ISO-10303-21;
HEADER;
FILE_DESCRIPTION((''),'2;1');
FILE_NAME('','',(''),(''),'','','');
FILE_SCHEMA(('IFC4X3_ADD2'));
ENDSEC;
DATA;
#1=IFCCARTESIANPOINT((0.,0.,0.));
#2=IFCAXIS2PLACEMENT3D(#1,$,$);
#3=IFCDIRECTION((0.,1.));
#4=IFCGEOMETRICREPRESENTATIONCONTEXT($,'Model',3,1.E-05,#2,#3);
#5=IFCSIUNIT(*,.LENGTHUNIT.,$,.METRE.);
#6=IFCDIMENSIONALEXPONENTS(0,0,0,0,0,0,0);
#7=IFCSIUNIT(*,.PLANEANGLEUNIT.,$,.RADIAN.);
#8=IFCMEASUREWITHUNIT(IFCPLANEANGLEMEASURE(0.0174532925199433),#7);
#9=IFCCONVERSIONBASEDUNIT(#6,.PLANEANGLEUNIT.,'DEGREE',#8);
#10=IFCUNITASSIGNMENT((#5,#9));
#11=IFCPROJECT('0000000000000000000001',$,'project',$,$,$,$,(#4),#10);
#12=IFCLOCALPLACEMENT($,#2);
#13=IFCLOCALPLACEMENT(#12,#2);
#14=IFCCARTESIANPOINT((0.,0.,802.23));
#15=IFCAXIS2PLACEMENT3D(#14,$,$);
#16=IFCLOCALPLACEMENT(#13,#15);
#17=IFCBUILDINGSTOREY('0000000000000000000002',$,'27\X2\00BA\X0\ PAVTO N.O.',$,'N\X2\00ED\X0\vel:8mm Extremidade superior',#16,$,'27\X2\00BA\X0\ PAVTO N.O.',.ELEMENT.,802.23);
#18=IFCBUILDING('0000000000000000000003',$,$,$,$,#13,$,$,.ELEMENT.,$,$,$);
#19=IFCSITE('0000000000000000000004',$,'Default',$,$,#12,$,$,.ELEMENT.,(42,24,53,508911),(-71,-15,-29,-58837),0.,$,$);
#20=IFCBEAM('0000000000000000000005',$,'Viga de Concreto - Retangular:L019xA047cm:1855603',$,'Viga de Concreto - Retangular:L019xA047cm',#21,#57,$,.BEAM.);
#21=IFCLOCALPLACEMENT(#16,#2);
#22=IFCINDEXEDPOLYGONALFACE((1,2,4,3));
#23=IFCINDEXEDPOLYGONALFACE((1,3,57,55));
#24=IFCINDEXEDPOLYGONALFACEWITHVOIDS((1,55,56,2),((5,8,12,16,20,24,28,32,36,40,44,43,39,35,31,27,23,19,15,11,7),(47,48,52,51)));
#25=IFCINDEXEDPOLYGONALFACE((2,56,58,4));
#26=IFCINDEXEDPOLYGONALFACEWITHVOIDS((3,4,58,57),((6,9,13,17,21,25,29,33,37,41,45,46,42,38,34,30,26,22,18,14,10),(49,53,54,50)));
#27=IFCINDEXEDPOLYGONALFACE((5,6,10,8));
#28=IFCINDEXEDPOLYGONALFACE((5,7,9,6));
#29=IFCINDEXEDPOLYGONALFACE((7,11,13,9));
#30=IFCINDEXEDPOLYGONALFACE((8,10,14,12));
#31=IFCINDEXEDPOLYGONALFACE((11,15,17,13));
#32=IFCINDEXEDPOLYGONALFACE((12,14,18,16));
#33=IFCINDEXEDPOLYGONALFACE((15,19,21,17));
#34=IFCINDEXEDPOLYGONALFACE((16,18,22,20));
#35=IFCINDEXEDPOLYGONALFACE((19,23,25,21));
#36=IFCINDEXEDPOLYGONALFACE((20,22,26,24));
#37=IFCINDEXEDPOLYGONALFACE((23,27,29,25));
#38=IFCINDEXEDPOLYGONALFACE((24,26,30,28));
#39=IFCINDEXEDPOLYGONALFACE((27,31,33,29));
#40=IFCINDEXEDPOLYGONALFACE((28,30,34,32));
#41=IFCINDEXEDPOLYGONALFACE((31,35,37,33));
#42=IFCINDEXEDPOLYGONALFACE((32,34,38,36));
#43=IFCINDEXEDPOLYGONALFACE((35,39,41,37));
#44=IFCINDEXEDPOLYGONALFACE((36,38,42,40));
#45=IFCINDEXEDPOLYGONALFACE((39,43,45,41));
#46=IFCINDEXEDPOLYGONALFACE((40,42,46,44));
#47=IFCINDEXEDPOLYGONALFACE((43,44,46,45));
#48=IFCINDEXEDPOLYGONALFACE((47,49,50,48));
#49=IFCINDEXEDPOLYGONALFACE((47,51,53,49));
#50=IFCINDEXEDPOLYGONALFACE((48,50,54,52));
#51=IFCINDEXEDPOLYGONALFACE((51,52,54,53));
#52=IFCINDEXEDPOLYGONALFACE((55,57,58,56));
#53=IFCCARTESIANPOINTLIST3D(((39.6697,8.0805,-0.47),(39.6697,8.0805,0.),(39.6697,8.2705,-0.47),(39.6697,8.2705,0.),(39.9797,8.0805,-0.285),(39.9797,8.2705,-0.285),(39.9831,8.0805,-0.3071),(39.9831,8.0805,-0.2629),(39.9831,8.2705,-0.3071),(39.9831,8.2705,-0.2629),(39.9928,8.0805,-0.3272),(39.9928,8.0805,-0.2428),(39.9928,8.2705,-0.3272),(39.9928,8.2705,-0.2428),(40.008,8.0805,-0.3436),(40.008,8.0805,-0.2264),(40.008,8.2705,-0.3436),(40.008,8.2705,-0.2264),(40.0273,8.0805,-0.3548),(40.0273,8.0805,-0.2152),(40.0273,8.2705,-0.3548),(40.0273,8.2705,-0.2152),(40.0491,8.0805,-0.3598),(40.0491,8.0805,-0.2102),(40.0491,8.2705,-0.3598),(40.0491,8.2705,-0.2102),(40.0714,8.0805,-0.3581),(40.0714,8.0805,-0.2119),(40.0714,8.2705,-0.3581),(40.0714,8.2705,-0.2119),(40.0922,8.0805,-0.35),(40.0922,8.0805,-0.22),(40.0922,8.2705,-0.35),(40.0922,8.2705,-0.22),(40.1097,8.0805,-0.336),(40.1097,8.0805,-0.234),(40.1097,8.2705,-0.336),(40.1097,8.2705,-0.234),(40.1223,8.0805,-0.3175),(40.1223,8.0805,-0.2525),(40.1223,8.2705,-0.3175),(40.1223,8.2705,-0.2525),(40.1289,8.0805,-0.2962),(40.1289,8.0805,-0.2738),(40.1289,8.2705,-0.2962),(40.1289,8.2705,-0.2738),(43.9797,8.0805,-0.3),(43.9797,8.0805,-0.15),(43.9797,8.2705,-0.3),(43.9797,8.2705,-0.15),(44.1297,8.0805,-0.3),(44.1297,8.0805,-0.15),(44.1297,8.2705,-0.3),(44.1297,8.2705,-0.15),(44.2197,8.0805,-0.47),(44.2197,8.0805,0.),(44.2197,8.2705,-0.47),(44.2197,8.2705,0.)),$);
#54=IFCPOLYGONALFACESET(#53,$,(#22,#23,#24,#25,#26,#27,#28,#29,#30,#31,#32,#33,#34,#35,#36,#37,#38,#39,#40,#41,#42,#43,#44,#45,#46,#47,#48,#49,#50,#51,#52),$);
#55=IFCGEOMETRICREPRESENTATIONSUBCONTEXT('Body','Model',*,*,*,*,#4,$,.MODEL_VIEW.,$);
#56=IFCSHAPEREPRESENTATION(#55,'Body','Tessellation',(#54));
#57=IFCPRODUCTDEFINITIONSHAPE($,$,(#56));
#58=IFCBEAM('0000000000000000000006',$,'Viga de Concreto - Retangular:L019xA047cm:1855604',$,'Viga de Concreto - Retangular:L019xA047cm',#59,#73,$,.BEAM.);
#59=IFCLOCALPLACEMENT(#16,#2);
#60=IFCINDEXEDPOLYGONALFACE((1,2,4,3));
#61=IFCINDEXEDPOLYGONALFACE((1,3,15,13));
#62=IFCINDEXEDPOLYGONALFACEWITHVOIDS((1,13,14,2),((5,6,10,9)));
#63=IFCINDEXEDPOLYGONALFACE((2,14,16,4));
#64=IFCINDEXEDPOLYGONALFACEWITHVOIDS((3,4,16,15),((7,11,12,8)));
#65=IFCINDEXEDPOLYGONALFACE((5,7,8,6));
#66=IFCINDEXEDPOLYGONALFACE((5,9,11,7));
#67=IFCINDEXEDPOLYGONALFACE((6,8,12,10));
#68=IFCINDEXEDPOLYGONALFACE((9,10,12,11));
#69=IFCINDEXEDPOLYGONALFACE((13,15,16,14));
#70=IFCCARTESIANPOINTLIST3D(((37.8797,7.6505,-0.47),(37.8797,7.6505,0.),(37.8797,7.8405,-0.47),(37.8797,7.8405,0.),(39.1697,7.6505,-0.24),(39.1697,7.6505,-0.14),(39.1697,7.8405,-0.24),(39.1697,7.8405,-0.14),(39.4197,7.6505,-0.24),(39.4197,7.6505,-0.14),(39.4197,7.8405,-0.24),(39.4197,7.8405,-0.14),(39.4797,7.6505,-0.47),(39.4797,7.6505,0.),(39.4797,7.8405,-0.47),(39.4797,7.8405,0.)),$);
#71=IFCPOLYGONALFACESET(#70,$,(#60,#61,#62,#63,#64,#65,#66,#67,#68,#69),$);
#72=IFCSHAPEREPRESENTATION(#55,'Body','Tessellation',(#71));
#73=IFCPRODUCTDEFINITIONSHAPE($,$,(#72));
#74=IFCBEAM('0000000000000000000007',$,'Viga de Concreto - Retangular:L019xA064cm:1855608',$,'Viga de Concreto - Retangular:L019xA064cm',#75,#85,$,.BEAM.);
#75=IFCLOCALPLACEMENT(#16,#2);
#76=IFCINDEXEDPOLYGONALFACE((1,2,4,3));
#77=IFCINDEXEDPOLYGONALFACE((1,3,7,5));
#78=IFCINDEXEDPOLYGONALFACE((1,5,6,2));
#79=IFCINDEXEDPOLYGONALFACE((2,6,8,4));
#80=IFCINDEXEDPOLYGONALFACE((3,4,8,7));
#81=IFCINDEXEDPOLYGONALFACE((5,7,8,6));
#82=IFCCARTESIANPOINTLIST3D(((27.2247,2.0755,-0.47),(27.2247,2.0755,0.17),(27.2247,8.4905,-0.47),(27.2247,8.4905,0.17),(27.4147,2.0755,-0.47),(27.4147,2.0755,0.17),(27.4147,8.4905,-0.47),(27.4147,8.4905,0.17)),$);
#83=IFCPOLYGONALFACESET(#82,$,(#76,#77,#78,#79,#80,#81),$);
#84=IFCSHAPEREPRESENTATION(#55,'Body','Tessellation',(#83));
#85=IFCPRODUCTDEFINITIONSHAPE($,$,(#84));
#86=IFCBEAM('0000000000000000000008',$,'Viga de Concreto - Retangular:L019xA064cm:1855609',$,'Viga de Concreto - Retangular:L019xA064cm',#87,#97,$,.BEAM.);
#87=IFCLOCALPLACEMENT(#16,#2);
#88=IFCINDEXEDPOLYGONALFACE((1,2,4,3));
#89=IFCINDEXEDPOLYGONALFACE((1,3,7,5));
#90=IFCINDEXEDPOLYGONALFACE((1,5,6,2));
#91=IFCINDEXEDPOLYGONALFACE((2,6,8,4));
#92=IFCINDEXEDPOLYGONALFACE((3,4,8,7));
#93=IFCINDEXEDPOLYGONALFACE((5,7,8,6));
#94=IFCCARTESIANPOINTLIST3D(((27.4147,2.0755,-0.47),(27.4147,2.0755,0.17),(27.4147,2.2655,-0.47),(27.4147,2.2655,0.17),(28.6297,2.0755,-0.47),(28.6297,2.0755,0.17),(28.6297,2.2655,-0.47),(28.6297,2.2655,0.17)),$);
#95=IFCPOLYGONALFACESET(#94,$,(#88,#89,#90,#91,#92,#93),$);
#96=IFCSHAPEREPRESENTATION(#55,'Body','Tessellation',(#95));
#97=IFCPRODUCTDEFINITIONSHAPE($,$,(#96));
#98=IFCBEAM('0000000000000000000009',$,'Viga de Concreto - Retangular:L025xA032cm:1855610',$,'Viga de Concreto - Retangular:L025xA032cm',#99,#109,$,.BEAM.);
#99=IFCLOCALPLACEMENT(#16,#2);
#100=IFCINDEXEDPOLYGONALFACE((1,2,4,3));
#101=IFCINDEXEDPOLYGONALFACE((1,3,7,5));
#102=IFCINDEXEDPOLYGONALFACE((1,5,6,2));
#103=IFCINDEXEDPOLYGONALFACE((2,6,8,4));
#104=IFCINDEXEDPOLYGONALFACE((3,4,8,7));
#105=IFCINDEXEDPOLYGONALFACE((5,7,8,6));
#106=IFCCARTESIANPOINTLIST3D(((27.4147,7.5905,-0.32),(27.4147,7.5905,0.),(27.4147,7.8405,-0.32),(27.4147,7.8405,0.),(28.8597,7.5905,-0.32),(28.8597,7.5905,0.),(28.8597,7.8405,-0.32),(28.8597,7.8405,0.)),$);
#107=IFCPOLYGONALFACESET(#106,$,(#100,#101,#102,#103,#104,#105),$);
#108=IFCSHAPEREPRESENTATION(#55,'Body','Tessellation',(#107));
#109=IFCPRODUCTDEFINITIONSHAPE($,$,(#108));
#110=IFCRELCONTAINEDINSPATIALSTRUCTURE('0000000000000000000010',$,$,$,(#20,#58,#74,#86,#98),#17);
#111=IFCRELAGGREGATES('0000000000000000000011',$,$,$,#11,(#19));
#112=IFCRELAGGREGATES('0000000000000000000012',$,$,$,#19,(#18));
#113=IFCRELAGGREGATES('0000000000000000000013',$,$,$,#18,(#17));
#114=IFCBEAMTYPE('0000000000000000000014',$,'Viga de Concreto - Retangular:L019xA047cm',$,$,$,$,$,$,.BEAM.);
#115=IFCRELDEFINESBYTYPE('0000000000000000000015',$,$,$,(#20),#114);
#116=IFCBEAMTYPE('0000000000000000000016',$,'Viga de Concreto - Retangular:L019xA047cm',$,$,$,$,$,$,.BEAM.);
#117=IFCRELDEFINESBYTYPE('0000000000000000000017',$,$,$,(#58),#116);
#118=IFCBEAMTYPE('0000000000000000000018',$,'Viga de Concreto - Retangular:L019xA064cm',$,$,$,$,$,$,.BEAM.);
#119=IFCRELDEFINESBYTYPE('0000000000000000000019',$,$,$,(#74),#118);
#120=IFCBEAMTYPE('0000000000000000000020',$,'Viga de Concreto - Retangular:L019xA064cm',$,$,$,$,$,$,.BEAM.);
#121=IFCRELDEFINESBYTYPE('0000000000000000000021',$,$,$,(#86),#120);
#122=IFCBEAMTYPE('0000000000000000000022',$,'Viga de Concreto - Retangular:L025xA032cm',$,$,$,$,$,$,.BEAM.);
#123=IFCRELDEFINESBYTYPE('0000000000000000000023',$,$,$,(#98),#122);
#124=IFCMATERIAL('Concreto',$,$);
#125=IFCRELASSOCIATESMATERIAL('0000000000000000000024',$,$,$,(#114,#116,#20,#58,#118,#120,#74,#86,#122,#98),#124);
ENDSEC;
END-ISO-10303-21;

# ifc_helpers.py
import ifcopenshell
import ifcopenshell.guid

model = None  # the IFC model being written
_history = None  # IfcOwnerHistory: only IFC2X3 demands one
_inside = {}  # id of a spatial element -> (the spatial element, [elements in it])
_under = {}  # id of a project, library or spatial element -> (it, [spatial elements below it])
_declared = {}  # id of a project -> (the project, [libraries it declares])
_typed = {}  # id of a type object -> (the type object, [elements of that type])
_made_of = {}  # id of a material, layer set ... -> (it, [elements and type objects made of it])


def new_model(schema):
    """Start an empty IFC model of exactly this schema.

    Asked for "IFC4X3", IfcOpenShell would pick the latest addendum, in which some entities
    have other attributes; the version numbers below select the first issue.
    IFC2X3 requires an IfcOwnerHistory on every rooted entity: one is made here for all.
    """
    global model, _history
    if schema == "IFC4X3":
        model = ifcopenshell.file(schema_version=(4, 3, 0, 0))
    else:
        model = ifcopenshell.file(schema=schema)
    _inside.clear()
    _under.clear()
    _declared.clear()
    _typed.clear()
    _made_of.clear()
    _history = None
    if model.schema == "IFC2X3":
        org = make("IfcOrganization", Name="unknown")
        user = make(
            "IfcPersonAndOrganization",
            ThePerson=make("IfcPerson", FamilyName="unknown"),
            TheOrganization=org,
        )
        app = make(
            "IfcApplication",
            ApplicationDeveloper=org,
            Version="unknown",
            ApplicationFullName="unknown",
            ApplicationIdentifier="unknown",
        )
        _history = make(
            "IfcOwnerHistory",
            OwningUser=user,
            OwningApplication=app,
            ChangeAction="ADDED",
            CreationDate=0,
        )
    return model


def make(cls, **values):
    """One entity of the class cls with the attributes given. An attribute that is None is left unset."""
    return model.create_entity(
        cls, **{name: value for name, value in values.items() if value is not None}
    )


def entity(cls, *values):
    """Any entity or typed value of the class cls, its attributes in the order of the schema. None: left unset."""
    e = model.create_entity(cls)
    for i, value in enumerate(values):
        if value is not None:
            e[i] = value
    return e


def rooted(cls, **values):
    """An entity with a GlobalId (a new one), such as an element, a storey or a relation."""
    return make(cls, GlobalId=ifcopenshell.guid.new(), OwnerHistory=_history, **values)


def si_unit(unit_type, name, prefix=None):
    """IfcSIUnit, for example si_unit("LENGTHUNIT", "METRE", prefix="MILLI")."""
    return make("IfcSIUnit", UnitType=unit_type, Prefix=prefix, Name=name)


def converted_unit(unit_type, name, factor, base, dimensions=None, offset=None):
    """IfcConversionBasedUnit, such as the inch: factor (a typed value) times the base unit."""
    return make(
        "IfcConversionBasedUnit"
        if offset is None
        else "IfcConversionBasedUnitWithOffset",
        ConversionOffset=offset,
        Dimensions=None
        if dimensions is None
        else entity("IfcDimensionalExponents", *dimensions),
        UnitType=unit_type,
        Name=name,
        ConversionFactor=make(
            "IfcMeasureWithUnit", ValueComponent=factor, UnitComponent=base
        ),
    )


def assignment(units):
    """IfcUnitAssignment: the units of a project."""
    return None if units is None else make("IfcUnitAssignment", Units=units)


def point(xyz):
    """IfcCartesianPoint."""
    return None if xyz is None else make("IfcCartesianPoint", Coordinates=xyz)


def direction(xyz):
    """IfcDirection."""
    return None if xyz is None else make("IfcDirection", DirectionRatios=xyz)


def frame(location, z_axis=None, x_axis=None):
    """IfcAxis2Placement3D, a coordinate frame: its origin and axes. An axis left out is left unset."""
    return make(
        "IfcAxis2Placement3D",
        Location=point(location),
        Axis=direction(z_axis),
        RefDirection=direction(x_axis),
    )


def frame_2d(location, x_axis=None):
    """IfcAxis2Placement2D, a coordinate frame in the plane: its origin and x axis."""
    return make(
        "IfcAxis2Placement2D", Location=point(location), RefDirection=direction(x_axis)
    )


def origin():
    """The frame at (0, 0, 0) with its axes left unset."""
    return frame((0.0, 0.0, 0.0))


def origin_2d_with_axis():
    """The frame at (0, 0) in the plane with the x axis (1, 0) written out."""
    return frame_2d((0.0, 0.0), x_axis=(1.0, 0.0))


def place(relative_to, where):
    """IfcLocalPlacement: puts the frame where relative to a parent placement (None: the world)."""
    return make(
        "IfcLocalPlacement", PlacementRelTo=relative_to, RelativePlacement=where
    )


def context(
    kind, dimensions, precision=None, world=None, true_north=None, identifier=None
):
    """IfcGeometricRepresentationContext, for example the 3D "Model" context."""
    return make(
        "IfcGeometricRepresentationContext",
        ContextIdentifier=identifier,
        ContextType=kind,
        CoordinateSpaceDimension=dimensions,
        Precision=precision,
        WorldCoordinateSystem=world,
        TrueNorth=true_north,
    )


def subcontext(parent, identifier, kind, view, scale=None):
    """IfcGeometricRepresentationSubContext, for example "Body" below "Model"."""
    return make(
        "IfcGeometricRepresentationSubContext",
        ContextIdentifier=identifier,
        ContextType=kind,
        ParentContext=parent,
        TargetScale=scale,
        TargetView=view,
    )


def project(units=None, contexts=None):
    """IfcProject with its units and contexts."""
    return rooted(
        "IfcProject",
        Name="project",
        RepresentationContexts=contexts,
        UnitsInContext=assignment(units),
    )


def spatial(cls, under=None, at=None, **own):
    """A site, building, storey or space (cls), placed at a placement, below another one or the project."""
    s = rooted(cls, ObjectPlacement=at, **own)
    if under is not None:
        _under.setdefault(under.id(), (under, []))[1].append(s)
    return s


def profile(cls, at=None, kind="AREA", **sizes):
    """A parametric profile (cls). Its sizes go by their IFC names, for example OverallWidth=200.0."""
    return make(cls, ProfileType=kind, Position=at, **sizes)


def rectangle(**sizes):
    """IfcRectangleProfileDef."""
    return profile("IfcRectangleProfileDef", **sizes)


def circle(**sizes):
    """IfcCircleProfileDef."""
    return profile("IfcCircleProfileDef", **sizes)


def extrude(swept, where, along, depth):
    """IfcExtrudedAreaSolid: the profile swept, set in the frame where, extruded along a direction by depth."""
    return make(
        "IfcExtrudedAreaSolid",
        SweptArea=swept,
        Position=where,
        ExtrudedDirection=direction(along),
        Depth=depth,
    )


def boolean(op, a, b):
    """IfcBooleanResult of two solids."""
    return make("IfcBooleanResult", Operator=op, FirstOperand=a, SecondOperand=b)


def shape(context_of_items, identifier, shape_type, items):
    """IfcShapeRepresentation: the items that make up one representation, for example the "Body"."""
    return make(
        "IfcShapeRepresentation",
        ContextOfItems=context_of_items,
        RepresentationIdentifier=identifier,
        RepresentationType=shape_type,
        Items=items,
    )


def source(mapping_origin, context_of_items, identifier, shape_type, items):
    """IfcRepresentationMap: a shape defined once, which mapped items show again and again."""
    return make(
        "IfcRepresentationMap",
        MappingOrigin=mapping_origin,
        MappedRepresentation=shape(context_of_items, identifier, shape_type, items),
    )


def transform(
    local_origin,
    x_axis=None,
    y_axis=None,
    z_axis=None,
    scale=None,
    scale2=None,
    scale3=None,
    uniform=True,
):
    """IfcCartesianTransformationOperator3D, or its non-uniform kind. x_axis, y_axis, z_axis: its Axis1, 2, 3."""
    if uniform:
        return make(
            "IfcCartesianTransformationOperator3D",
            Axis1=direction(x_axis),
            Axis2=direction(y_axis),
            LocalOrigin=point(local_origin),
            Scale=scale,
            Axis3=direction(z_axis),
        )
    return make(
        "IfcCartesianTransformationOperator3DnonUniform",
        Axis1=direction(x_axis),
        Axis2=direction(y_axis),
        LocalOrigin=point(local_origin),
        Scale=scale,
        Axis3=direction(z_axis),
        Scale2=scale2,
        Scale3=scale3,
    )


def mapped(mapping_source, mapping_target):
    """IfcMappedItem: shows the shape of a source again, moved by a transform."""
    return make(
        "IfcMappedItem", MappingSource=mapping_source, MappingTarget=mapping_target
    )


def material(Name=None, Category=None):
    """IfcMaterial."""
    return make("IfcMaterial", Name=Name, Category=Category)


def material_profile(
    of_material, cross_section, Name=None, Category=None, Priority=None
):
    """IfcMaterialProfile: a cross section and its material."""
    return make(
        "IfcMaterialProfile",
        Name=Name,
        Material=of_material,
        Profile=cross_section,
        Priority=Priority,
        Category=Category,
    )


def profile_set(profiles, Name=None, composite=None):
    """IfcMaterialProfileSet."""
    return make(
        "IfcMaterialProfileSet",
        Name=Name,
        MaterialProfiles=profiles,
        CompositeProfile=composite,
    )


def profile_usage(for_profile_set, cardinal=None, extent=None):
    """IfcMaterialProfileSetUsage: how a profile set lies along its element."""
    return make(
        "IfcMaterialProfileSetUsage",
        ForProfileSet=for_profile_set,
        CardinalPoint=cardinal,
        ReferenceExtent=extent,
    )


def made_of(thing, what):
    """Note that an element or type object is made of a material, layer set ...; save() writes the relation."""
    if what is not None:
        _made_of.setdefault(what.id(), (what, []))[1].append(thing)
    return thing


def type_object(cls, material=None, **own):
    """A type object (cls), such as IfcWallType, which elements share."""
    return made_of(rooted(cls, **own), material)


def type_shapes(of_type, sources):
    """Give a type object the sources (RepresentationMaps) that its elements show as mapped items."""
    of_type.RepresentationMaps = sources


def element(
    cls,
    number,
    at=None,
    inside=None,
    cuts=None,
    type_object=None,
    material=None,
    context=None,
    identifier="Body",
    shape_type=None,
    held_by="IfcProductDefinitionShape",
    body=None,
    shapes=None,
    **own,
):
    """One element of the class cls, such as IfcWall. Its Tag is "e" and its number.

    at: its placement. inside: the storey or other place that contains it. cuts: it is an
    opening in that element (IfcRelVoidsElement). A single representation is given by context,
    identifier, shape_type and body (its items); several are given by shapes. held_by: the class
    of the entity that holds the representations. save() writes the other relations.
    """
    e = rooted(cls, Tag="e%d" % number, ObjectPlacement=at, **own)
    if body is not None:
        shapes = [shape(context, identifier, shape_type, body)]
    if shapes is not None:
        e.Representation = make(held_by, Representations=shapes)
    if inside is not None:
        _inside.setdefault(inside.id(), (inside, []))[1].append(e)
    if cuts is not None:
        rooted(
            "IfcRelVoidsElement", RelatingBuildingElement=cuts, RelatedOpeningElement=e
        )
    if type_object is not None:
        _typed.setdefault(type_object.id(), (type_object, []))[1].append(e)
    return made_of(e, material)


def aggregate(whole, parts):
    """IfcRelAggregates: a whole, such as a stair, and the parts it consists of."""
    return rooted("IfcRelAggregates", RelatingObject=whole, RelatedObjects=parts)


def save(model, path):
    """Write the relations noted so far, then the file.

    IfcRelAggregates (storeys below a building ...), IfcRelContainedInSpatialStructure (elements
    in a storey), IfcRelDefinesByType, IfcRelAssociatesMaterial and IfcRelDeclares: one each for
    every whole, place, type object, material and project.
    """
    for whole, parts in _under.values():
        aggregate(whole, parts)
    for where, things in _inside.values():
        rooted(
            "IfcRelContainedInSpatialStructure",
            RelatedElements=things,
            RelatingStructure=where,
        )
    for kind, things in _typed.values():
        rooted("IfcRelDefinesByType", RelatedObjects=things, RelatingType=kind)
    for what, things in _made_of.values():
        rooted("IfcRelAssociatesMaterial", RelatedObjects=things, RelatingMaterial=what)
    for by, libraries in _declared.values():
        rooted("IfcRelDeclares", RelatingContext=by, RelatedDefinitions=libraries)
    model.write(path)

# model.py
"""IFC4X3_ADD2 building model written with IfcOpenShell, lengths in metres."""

from ifc_helpers import new_model, entity, si_unit, converted_unit, direction, frame, frame_2d, origin, origin_2d_with_axis, place, context, subcontext, project, spatial, rectangle, circle, extrude, boolean, source, transform, mapped, material, material_profile, profile_set, profile_usage, type_object, type_shapes, element, save


model = new_model("IFC4X3_ADD2")

# Units and contexts
model_context = context("Model", 3, precision=1e-05, world=origin(), true_north=direction((0.0, 1.0)))
body_context = subcontext(model_context, "Body", "Model", "MODEL_VIEW")
ifc_project = project(units=[si_unit("LENGTHUNIT", "METRE"), converted_unit("PLANEANGLEUNIT", "DEGREE", entity("IfcPlaneAngleMeasure", 0.0174532925199433), si_unit("PLANEANGLEUNIT", "RADIAN"), dimensions=[0, 0, 0, 0, 0, 0, 0])], contexts=[model_context])

# Site, building, storey
site_placement = place(None, origin())
site = spatial("IfcSite", under=ifc_project, at=site_placement, Name="Default", CompositionType="ELEMENT", RefLatitude=(42, 24, 53, 508911), RefLongitude=(-71, -15, -29, -58837), RefElevation=0.0)
building_placement = place(site_placement, origin())
building = spatial("IfcBuilding", under=site, at=building_placement, CompositionType="ELEMENT")
storey_placement = place(building_placement, frame((0.0, 0.0, 802.23)))
storey = spatial("IfcBuildingStorey", under=building, at=storey_placement, Name="27º PAVTO N.O.", ObjectType="Nível:8mm Extremidade superior", LongName="27º PAVTO N.O.", CompositionType="ELEMENT", Elevation=802.23)

# Beams
ifc_material = material(Name="Concreto")
ifc_material_profile_1 = material_profile(ifc_material, rectangle(XDim=0.64, YDim=0.19, at=frame_2d((0.0, 0.0), x_axis=(1.0, 0.0))), Name="L019xA064cm")
ifc_profile_set_1 = profile_set([ifc_material_profile_1], Name="L019xA064cm")
ifc_profile_usage_1 = profile_usage(ifc_profile_set_1, cardinal=8)
ifc_material_profile_2 = material_profile(ifc_material, rectangle(XDim=0.47, YDim=0.19, at=frame_2d((0.0, 0.0), x_axis=(0.0, 1.0))), Name="L019xA047cm")
ifc_profile_set_2 = profile_set([ifc_material_profile_2], Name="L019xA047cm")
beam_type_1 = type_object("IfcBeamType", Name="Viga de Concreto - Retangular:L019xA047cm", PredefinedType="BEAM", material=ifc_profile_set_2)
shared_shape_1 = source(origin(), body_context, "Body", "CSG", [
    boolean("DIFFERENCE", boolean("DIFFERENCE", extrude(rectangle(XDim=0.47, YDim=0.19, at=frame_2d((0.0, 0.0), x_axis=(0.0, 1.0))), frame((39.6697, 8.1755, 801.995), z_axis=(1.0, 0.0, 0.0), x_axis=(0.0, 1.0, 0.0)), (0.0, 0.0, 1.0), 4.55), extrude(circle(Radius=0.075, at=origin_2d_with_axis()), frame((40.0547, 8.2705, 801.945), z_axis=(0.0, -1.0, 0.0), x_axis=(-1.0, 0.0, 0.0)), (0.0, 0.0, 1.0), 0.19)), extrude(rectangle(XDim=0.15, YDim=0.15, at=frame_2d((0.0, 0.0), x_axis=(0.0, 1.0))), frame((44.0547, 8.0805, 802.005), z_axis=(0.0, 1.0, 0.0), x_axis=(1.0, 0.0, 0.0)), (0.0, 0.0, 1.0), 0.19)),
])
type_shapes(beam_type_1, [shared_shape_1])
beam_1_placement = place(storey_placement, frame((0.0, 0.0, -802.23)))
element("IfcBeam", 1, at=beam_1_placement, inside=storey, type_object=beam_type_1, material=ifc_material, Name="Viga de Concreto - Retangular:L019xA047cm:1855603", ObjectType="Viga de Concreto - Retangular:L019xA047cm", PredefinedType="BEAM", context=body_context, shape_type="MappedRepresentation", body=[
    mapped(shared_shape_1, transform((0.0, 0.0, 0.0), scale=1.0)),
])
beam_type_2 = type_object("IfcBeamType", Name="Viga de Concreto - Retangular:L019xA047cm", PredefinedType="BEAM", material=ifc_profile_set_2)
shared_shape_2 = source(origin(), body_context, "Body", "CSG", [
    boolean("DIFFERENCE", extrude(rectangle(XDim=0.47, YDim=0.19, at=frame_2d((0.0, 0.0), x_axis=(0.0, 1.0))), frame((37.8797, 7.7455, 801.995), z_axis=(1.0, 0.0, 0.0), x_axis=(0.0, 1.0, 0.0)), (0.0, 0.0, 1.0), 1.6), extrude(rectangle(XDim=0.1, YDim=0.25, at=frame_2d((0.0, 0.0), x_axis=(0.0, 1.0))), frame((39.2947, 7.8405, 802.04), z_axis=(0.0, -1.0, 0.0), x_axis=(-1.0, 0.0, 0.0)), (0.0, 0.0, 1.0), 0.19)),
])
type_shapes(beam_type_2, [shared_shape_2])
beam_2_placement = place(storey_placement, frame((0.0, 0.0, -802.23)))
element("IfcBeam", 2, at=beam_2_placement, inside=storey, type_object=beam_type_2, material=ifc_material, Name="Viga de Concreto - Retangular:L019xA047cm:1855604", ObjectType="Viga de Concreto - Retangular:L019xA047cm", PredefinedType="BEAM", context=body_context, shape_type="MappedRepresentation", body=[
    mapped(shared_shape_2, transform((0.0, 0.0, 0.0), scale=1.0)),
])
beam_type_3 = type_object("IfcBeamType", Name="Viga de Concreto - Retangular:L019xA064cm", PredefinedType="BEAM", material=ifc_profile_set_1)
shared_shape_3 = source(origin(), body_context, "Body", "SweptSolid", [
    extrude(rectangle(XDim=0.64, YDim=0.19, at=frame_2d((0.0, 0.0), x_axis=(0.0, 1.0))), frame((27.3197, 8.4905, 802.08), z_axis=(0.0, -1.0, 0.0), x_axis=(-1.0, 0.0, 0.0)), (0.0, 0.0, 1.0), 6.415),
])
type_shapes(beam_type_3, [shared_shape_3])
beam_3_placement = place(storey_placement, frame((0.0, 0.0, -802.23)))
element("IfcBeam", 3, at=beam_3_placement, inside=storey, type_object=beam_type_3, material=ifc_profile_usage_1, Name="Viga de Concreto - Retangular:L019xA064cm:1855608", ObjectType="Viga de Concreto - Retangular:L019xA064cm", PredefinedType="BEAM", context=body_context, shape_type="MappedRepresentation", body=[
    mapped(shared_shape_3, transform((0.0, 0.0, 0.0), scale=1.0)),
])
beam_type_4 = type_object("IfcBeamType", Name="Viga de Concreto - Retangular:L019xA064cm", PredefinedType="BEAM", material=ifc_profile_set_1)
shared_shape_4 = source(origin(), body_context, "Body", "SweptSolid", [
    extrude(rectangle(XDim=0.64, YDim=0.19, at=frame_2d((0.0, 0.0), x_axis=(1.0, 0.0))), frame((28.6297, 2.1705, 802.08), z_axis=(-1.0, 0.0, 0.0), x_axis=(0.0, 0.0, -1.0)), (0.0, 0.0, 1.0), 1.215),
])
type_shapes(beam_type_4, [shared_shape_4])
beam_4_placement = place(storey_placement, frame((0.0, 0.0, -802.23)))
element("IfcBeam", 4, at=beam_4_placement, inside=storey, type_object=beam_type_4, material=ifc_profile_usage_1, Name="Viga de Concreto - Retangular:L019xA064cm:1855609", ObjectType="Viga de Concreto - Retangular:L019xA064cm", PredefinedType="BEAM", context=body_context, shape_type="MappedRepresentation", body=[
    mapped(shared_shape_4, transform((0.0, 0.0, 0.0), scale=1.0)),
])
ifc_material_profile_3 = material_profile(ifc_material, rectangle(XDim=0.32, YDim=0.25, at=frame_2d((0.0, 0.0), x_axis=(1.0, 0.0))), Name="L025xA032cm")
ifc_profile_set_3 = profile_set([ifc_material_profile_3], Name="L025xA032cm")
ifc_profile_usage_2 = profile_usage(ifc_profile_set_3, cardinal=8)
beam_type_5 = type_object("IfcBeamType", Name="Viga de Concreto - Retangular:L025xA032cm", PredefinedType="BEAM", material=ifc_profile_set_3)
shared_shape_5 = source(origin(), body_context, "Body", "SweptSolid", [
    extrude(rectangle(XDim=0.32, YDim=0.25, at=frame_2d((0.0, 0.0), x_axis=(1.0, 0.0))), frame((28.8597, 7.7155, 802.07), z_axis=(-1.0, 0.0, 0.0), x_axis=(0.0, 0.0, -1.0)), (0.0, 0.0, 1.0), 1.445),
])
type_shapes(beam_type_5, [shared_shape_5])
beam_5_placement = place(storey_placement, frame((0.0, 0.0, -802.23)))
element("IfcBeam", 5, at=beam_5_placement, inside=storey, type_object=beam_type_5, material=ifc_profile_usage_2, Name="Viga de Concreto - Retangular:L025xA032cm:1855610", ObjectType="Viga de Concreto - Retangular:L025xA032cm", PredefinedType="BEAM", context=body_context, shape_type="MappedRepresentation", body=[
    mapped(shared_shape_5, transform((0.0, 0.0, 0.0), scale=1.0)),
])

save(model, "model.ifc")
